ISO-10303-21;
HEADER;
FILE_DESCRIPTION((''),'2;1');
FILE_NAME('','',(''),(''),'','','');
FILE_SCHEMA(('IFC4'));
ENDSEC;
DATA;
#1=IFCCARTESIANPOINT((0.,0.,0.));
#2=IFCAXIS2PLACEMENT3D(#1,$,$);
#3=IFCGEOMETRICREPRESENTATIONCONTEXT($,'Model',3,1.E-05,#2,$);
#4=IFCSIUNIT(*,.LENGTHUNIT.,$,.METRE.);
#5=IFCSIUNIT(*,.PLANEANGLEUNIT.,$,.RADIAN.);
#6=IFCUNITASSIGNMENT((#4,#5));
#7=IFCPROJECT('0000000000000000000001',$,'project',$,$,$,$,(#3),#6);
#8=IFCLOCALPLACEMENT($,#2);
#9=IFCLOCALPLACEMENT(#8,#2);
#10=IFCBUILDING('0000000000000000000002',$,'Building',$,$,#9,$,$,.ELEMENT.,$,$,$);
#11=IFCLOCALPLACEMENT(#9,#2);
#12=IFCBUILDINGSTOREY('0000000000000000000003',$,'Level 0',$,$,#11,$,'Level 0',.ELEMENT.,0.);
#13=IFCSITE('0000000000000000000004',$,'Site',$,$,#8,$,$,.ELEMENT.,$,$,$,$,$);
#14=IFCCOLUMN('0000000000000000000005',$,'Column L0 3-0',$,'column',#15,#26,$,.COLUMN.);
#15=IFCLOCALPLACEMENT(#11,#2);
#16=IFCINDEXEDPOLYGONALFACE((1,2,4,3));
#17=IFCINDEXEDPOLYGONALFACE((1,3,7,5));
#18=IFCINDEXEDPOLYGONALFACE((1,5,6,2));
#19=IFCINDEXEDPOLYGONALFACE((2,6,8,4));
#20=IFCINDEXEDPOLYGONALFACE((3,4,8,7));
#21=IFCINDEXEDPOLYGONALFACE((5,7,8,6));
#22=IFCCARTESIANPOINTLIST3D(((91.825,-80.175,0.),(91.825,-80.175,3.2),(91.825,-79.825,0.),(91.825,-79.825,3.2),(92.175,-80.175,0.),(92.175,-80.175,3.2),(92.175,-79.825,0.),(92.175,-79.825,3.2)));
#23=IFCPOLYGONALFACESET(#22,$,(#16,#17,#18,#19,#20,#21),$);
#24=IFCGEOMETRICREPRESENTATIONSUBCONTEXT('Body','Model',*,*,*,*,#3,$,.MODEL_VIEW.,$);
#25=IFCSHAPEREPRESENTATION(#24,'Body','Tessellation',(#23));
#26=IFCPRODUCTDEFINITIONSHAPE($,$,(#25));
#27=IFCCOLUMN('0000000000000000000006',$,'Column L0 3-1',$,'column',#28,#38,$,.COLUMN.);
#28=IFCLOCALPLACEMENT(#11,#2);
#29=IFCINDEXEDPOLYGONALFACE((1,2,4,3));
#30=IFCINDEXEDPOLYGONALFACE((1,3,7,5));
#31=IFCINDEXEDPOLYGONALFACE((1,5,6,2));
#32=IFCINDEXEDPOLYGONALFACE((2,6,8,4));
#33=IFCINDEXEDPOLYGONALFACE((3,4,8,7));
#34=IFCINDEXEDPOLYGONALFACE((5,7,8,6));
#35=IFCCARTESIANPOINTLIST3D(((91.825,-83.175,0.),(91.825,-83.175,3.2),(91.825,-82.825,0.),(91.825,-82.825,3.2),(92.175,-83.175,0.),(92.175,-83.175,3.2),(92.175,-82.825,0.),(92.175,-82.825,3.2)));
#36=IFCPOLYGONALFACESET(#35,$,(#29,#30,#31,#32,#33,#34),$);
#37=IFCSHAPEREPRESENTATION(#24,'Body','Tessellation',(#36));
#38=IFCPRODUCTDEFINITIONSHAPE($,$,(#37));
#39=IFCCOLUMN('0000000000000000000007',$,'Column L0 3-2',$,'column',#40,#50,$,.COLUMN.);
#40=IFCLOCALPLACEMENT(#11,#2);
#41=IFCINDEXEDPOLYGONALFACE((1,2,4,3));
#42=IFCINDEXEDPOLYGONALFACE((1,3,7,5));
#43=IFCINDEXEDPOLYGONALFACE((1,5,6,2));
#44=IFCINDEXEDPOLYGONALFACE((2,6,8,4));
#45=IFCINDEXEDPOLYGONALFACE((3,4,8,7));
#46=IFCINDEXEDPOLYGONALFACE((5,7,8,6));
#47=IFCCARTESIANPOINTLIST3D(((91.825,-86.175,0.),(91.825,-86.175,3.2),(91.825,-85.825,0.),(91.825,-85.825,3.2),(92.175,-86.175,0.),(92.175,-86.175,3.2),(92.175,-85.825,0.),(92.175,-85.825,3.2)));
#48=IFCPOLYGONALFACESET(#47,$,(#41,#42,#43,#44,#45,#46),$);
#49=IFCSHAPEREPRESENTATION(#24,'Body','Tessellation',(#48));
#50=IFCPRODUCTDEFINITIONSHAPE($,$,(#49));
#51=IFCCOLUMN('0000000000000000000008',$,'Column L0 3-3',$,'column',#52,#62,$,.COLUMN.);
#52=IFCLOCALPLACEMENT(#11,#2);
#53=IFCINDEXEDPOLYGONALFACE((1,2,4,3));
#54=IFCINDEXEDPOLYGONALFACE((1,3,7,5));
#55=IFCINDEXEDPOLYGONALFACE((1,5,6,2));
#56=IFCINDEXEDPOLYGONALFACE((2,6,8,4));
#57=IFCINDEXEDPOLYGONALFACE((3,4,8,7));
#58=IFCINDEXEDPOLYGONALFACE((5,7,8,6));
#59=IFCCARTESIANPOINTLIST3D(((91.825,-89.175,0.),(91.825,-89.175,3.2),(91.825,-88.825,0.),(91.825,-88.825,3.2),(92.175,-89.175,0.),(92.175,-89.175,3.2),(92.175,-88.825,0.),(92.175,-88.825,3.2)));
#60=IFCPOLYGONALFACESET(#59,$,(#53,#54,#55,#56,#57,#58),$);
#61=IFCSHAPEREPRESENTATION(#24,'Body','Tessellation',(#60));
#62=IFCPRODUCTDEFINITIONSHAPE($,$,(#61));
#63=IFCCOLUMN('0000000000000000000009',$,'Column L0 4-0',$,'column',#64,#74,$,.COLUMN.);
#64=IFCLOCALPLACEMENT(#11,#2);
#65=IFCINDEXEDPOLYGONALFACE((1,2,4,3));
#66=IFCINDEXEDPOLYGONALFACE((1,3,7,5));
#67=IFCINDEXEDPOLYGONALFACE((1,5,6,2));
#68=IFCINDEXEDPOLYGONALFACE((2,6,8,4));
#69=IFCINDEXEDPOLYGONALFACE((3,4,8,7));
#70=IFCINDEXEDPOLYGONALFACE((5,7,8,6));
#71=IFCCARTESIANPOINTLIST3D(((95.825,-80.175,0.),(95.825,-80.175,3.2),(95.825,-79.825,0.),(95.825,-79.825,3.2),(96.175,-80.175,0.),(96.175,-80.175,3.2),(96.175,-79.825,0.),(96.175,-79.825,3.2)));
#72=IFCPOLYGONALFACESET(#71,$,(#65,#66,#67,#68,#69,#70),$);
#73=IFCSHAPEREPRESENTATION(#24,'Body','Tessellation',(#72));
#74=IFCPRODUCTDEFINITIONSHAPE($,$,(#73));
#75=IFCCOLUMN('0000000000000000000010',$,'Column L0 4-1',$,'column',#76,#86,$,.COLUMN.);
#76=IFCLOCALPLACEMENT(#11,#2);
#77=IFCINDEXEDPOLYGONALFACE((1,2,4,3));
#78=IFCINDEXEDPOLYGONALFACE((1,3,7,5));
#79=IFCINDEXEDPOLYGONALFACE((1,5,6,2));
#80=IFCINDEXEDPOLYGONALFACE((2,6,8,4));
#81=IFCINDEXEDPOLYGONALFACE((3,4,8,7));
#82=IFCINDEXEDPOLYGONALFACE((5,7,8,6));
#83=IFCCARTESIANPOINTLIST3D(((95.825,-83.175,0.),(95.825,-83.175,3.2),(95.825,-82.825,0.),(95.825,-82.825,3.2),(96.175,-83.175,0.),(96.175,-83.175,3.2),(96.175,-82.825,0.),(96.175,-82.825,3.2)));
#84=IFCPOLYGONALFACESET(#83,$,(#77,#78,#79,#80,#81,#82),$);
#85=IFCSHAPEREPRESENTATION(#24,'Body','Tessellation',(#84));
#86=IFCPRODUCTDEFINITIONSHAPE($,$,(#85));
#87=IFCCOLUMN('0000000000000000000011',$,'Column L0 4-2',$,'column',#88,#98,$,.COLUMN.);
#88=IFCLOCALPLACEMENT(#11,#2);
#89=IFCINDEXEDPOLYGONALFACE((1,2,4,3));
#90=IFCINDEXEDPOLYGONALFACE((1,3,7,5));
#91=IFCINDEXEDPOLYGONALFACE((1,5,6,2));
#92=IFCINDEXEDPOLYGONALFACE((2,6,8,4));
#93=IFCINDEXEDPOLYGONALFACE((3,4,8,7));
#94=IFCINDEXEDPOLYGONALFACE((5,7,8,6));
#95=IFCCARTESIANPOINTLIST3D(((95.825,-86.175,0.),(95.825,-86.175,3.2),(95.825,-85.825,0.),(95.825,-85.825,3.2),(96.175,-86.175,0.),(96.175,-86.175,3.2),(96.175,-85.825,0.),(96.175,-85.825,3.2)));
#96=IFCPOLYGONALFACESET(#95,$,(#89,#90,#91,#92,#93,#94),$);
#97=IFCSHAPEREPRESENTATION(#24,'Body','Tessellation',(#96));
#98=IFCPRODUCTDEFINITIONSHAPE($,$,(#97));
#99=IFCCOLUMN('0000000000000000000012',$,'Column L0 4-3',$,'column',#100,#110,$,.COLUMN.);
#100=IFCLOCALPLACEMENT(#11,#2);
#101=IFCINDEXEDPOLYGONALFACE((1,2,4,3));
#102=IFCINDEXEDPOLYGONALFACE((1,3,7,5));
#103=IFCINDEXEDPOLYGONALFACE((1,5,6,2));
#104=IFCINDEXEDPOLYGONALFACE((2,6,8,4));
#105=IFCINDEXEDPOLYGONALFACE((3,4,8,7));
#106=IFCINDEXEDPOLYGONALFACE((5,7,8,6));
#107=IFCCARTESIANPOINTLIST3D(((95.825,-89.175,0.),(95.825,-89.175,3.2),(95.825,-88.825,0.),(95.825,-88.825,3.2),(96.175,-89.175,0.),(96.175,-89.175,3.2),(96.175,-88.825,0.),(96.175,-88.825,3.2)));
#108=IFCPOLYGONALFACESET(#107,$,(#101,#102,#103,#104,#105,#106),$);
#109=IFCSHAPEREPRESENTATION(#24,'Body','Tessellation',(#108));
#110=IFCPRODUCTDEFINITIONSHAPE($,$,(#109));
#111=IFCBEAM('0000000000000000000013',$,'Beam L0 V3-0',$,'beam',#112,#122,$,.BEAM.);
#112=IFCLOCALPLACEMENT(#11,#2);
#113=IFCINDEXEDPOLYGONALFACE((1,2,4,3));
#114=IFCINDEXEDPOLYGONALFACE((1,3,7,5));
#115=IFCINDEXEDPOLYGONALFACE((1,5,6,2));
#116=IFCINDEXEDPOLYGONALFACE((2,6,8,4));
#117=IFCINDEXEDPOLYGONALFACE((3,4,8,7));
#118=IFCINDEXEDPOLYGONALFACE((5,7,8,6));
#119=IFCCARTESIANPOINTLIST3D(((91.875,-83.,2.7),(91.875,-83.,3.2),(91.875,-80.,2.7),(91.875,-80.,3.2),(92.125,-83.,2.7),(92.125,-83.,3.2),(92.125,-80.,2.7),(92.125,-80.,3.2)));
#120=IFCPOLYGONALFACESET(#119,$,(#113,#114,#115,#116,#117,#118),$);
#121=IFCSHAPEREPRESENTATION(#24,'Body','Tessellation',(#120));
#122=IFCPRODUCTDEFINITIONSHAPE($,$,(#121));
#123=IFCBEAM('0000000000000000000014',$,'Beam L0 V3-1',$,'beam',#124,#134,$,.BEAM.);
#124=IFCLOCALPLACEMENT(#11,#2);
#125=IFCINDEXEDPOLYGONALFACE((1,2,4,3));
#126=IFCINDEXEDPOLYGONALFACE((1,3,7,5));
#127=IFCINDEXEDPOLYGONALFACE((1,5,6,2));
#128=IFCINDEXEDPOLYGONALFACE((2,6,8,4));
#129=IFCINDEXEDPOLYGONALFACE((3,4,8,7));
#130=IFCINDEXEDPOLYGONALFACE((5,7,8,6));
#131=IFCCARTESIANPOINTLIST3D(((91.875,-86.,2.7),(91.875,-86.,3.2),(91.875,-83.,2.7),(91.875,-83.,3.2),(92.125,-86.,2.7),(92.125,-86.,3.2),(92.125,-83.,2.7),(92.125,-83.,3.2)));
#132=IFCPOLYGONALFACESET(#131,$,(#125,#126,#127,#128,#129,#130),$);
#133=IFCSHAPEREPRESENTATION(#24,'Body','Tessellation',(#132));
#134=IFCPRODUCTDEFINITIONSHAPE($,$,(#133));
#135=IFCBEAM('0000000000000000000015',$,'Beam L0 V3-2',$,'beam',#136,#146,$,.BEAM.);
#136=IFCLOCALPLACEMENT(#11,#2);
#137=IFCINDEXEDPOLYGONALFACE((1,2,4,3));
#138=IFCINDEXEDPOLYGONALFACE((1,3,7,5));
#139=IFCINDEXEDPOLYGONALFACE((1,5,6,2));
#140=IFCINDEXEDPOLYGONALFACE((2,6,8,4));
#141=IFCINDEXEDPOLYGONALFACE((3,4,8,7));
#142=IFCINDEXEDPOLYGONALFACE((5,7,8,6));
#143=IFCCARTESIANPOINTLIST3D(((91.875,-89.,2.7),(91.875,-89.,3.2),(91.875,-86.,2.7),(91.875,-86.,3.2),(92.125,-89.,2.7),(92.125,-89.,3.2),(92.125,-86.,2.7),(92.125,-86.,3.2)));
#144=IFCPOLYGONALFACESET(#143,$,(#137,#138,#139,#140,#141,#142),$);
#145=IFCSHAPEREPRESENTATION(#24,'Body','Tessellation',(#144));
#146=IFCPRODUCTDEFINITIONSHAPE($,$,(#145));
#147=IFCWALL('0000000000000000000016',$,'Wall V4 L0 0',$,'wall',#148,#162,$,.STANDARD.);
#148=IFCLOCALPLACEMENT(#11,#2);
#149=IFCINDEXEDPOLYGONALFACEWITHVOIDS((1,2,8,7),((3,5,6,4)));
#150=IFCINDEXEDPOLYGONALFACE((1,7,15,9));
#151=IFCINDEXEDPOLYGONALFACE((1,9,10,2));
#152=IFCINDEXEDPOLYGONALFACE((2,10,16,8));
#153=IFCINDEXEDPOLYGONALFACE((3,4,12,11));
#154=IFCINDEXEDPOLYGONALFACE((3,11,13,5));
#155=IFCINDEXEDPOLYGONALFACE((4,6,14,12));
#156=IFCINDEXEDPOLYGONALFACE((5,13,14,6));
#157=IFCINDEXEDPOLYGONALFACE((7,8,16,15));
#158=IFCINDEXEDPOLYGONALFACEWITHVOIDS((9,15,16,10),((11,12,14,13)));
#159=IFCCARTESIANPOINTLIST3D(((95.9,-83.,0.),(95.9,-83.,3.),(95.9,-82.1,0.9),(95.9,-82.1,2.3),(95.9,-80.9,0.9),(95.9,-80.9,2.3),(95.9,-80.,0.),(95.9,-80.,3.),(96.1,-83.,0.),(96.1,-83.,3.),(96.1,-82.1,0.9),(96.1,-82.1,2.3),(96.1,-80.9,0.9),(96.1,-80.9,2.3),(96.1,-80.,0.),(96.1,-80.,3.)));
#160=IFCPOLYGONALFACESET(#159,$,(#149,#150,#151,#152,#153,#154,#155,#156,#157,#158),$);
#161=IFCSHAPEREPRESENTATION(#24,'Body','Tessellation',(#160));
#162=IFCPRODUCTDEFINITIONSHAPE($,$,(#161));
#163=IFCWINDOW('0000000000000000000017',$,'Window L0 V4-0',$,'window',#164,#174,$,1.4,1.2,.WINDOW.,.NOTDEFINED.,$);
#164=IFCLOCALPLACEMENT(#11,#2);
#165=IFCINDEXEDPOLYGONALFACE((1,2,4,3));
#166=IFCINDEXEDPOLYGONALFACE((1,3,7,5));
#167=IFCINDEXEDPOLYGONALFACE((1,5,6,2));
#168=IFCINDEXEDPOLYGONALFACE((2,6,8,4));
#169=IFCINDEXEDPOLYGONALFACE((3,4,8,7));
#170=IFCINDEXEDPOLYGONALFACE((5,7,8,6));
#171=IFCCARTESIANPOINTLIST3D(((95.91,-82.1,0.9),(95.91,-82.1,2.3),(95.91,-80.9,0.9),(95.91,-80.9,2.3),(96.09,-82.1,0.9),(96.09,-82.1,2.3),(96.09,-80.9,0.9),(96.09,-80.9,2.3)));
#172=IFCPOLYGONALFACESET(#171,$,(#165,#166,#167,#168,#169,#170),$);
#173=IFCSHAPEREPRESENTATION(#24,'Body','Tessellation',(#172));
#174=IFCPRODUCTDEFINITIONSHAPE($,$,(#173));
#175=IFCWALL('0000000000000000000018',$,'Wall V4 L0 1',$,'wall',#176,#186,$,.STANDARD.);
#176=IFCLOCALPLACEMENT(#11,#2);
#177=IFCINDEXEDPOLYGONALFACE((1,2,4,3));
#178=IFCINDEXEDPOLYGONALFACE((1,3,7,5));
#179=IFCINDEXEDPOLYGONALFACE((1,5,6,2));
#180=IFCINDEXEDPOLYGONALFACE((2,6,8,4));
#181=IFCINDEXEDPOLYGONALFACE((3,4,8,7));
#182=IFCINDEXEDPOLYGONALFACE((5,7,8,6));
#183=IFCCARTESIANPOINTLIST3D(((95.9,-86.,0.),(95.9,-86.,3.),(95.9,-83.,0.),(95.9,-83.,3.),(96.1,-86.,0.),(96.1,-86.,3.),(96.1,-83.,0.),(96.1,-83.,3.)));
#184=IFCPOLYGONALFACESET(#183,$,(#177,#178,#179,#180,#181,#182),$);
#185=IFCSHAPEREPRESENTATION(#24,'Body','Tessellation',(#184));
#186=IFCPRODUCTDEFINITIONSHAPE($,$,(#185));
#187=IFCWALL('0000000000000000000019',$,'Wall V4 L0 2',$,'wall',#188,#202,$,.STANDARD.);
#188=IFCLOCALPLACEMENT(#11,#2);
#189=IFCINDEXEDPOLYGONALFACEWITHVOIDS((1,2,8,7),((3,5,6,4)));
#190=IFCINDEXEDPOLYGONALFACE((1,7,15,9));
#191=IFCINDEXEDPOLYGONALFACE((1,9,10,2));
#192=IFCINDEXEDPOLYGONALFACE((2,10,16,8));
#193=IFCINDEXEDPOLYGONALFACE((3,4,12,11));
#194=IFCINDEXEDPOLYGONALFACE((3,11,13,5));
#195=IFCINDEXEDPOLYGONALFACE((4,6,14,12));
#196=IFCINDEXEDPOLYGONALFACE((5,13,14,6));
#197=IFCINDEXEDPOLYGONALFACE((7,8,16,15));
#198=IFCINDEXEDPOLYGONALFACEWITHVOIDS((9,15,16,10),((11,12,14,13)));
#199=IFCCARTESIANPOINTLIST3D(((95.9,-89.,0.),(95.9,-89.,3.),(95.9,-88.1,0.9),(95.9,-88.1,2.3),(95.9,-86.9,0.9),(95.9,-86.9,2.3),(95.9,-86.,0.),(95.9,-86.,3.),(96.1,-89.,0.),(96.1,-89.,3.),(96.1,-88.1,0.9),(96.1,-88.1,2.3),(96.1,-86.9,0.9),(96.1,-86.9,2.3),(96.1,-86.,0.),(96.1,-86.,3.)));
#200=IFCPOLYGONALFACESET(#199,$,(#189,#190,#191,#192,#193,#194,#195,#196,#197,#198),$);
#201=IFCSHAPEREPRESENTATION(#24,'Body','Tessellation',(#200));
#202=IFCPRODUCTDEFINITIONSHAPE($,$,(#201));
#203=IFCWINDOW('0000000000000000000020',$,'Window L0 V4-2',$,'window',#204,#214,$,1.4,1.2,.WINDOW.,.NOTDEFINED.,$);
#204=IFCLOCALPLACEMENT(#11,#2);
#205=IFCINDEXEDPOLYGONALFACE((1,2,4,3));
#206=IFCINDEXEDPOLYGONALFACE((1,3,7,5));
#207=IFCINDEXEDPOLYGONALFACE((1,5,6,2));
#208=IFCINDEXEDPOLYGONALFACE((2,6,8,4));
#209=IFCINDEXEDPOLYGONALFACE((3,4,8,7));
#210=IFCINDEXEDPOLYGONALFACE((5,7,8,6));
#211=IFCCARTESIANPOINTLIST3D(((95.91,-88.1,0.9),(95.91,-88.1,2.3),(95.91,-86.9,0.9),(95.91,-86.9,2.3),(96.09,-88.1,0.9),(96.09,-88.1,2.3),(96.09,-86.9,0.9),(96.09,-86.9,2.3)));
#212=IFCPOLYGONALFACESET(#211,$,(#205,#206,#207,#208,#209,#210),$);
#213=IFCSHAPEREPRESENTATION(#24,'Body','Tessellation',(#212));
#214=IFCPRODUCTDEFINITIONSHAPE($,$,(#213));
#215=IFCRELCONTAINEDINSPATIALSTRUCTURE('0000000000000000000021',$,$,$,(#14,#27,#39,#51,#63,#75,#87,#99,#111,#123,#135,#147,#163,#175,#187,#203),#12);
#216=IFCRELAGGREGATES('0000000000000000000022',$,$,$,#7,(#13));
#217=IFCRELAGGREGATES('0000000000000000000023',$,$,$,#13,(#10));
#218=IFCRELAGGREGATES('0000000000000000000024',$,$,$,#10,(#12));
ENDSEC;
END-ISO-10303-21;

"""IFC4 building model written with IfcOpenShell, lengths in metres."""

from ifc_helpers import new_model, si_unit, frame, frame_2d, origin, origin_2d, place, context, subcontext, project, spatial, rectangle, extrude, element, fill, save


model = new_model("IFC4")

# Units and contexts
model_context = context("Model", 3, precision=1e-05, world=origin())
body_context = subcontext(model_context, "Body", "Model", "MODEL_VIEW")
ifc_project = project(units=[si_unit("LENGTHUNIT", "METRE"), si_unit("PLANEANGLEUNIT", "RADIAN")], contexts=[model_context])

# Site, building, storey
site_placement = place(None, origin())
site = spatial("IfcSite", under=ifc_project, at=site_placement, Name="Site", CompositionType="ELEMENT")
building_placement = place(site_placement, origin())
building = spatial("IfcBuilding", under=site, at=building_placement, Name="Building", CompositionType="ELEMENT")
storey_placement = place(building_placement, origin())
storey = spatial("IfcBuildingStorey", under=building, at=storey_placement, Name="Level 0", LongName="Level 0", CompositionType="ELEMENT", Elevation=0.0)

# Columns
for number, where, name in (
    (1, (92.0, -80.0, 0.0), "Column L0 3-0"),
    (2, (92.0, -83.0, 0.0), "Column L0 3-1"),
    (3, (92.0, -86.0, 0.0), "Column L0 3-2"),
    (4, (92.0, -89.0, 0.0), "Column L0 3-3"),
    (5, (96.0, -80.0, 0.0), "Column L0 4-0"),
    (6, (96.0, -83.0, 0.0), "Column L0 4-1"),
    (7, (96.0, -86.0, 0.0), "Column L0 4-2"),
    (8, (96.0, -89.0, 0.0), "Column L0 4-3"),
):
    element("IfcColumn", number, at=place(storey_placement, frame(where)), inside=storey, Name=name, ObjectType="column", PredefinedType="COLUMN", context=body_context, shape_type="SweptSolid", body=[
        extrude(rectangle(XDim=0.35, YDim=0.35, at=origin_2d()), origin(), (0.0, 0.0, 1.0), 3.2),
    ])

# Beams
for number, where, z_axis, x_axis, name in (
    (9, (92.0, -80.0, 2.95), (0.0, -1.0, 0.0), (0.0, 0.0, 1.0), "Beam L0 V3-0"),
    (10, (92.0, -83.0, 2.95), (0.0, -1.0, 0.0), (0.0, 0.0, 1.0), "Beam L0 V3-1"),
    (11, (92.0, -86.0, 2.95), (0.0, -1.0, 0.0), (0.0, 0.0, 1.0), "Beam L0 V3-2"),
):
    element("IfcBeam", number, at=place(storey_placement, frame(where, z_axis=z_axis, x_axis=x_axis)), inside=storey, Name=name, ObjectType="beam", PredefinedType="BEAM", context=body_context, shape_type="SweptSolid", body=[
        extrude(rectangle(XDim=0.5, YDim=0.25, at=origin_2d()), origin(), (0.0, 0.0, 1.0), 3.0),
    ])

# Wall, opening, window
wall_1_placement = place(storey_placement, frame((96.0, -80.0, 0.0), z_axis=(0.0, 0.0, 1.0), x_axis=(0.0, -1.0, 0.0)))
wall_1 = element("IfcWall", 12, at=wall_1_placement, inside=storey, Name="Wall V4 L0 0", ObjectType="wall", PredefinedType="STANDARD", context=body_context, shape_type="SweptSolid", body=[
    extrude(rectangle(XDim=3.0, YDim=0.2, at=frame_2d((1.5, 0.0))), origin(), (0.0, 0.0, 1.0), 3.0),
])
opening_1_placement = place(storey_placement, frame((96.0, -81.5, 0.9), z_axis=(0.0, 0.0, 1.0), x_axis=(0.0, -1.0, 0.0)))
opening_1 = element("IfcOpeningElement", 13, at=opening_1_placement, cuts=wall_1, ObjectType="Opening", PredefinedType="OPENING", context=body_context, shape_type="SweptSolid", body=[
    extrude(rectangle(XDim=1.2, YDim=0.22, at=origin_2d()), origin(), (0.0, 0.0, 1.0), 1.4),
])
window_1_placement = place(storey_placement, frame((96.0, -81.5, 0.9), z_axis=(0.0, 0.0, 1.0), x_axis=(0.0, -1.0, 0.0)))
window_1 = element("IfcWindow", 14, at=window_1_placement, inside=storey, Name="Window L0 V4-0", ObjectType="window", OverallHeight=1.4, OverallWidth=1.2, PartitioningType="NOTDEFINED", PredefinedType="WINDOW", context=body_context, shape_type="SweptSolid", body=[
    extrude(rectangle(XDim=1.2, YDim=0.18, at=origin_2d()), origin(), (0.0, 0.0, 1.0), 1.4),
])
fill(opening_1, window_1)

# Wall
wall_2_placement = place(storey_placement, frame((96.0, -83.0, 0.0), z_axis=(0.0, 0.0, 1.0), x_axis=(0.0, -1.0, 0.0)))
element("IfcWall", 15, at=wall_2_placement, inside=storey, Name="Wall V4 L0 1", ObjectType="wall", PredefinedType="STANDARD", context=body_context, shape_type="SweptSolid", body=[
    extrude(rectangle(XDim=3.0, YDim=0.2, at=frame_2d((1.5, 0.0))), origin(), (0.0, 0.0, 1.0), 3.0),
])

# Wall, opening, window
wall_3_placement = place(storey_placement, frame((96.0, -86.0, 0.0), z_axis=(0.0, 0.0, 1.0), x_axis=(0.0, -1.0, 0.0)))
wall_3 = element("IfcWall", 16, at=wall_3_placement, inside=storey, Name="Wall V4 L0 2", ObjectType="wall", PredefinedType="STANDARD", context=body_context, shape_type="SweptSolid", body=[
    extrude(rectangle(XDim=3.0, YDim=0.2, at=frame_2d((1.5, 0.0))), origin(), (0.0, 0.0, 1.0), 3.0),
])
opening_2_placement = place(storey_placement, frame((96.0, -87.5, 0.9), z_axis=(0.0, 0.0, 1.0), x_axis=(0.0, -1.0, 0.0)))
opening_2 = element("IfcOpeningElement", 17, at=opening_2_placement, cuts=wall_3, ObjectType="Opening", PredefinedType="OPENING", context=body_context, shape_type="SweptSolid", body=[
    extrude(rectangle(XDim=1.2, YDim=0.22, at=origin_2d()), origin(), (0.0, 0.0, 1.0), 1.4),
])
window_2_placement = place(storey_placement, frame((96.0, -87.5, 0.9), z_axis=(0.0, 0.0, 1.0), x_axis=(0.0, -1.0, 0.0)))
window_2 = element("IfcWindow", 18, at=window_2_placement, inside=storey, Name="Window L0 V4-2", ObjectType="window", OverallHeight=1.4, OverallWidth=1.2, PartitioningType="NOTDEFINED", PredefinedType="WINDOW", context=body_context, shape_type="SweptSolid", body=[
    extrude(rectangle(XDim=1.2, YDim=0.18, at=origin_2d()), origin(), (0.0, 0.0, 1.0), 1.4),
])
fill(opening_2, window_2)

save(model, "model.ifc")
